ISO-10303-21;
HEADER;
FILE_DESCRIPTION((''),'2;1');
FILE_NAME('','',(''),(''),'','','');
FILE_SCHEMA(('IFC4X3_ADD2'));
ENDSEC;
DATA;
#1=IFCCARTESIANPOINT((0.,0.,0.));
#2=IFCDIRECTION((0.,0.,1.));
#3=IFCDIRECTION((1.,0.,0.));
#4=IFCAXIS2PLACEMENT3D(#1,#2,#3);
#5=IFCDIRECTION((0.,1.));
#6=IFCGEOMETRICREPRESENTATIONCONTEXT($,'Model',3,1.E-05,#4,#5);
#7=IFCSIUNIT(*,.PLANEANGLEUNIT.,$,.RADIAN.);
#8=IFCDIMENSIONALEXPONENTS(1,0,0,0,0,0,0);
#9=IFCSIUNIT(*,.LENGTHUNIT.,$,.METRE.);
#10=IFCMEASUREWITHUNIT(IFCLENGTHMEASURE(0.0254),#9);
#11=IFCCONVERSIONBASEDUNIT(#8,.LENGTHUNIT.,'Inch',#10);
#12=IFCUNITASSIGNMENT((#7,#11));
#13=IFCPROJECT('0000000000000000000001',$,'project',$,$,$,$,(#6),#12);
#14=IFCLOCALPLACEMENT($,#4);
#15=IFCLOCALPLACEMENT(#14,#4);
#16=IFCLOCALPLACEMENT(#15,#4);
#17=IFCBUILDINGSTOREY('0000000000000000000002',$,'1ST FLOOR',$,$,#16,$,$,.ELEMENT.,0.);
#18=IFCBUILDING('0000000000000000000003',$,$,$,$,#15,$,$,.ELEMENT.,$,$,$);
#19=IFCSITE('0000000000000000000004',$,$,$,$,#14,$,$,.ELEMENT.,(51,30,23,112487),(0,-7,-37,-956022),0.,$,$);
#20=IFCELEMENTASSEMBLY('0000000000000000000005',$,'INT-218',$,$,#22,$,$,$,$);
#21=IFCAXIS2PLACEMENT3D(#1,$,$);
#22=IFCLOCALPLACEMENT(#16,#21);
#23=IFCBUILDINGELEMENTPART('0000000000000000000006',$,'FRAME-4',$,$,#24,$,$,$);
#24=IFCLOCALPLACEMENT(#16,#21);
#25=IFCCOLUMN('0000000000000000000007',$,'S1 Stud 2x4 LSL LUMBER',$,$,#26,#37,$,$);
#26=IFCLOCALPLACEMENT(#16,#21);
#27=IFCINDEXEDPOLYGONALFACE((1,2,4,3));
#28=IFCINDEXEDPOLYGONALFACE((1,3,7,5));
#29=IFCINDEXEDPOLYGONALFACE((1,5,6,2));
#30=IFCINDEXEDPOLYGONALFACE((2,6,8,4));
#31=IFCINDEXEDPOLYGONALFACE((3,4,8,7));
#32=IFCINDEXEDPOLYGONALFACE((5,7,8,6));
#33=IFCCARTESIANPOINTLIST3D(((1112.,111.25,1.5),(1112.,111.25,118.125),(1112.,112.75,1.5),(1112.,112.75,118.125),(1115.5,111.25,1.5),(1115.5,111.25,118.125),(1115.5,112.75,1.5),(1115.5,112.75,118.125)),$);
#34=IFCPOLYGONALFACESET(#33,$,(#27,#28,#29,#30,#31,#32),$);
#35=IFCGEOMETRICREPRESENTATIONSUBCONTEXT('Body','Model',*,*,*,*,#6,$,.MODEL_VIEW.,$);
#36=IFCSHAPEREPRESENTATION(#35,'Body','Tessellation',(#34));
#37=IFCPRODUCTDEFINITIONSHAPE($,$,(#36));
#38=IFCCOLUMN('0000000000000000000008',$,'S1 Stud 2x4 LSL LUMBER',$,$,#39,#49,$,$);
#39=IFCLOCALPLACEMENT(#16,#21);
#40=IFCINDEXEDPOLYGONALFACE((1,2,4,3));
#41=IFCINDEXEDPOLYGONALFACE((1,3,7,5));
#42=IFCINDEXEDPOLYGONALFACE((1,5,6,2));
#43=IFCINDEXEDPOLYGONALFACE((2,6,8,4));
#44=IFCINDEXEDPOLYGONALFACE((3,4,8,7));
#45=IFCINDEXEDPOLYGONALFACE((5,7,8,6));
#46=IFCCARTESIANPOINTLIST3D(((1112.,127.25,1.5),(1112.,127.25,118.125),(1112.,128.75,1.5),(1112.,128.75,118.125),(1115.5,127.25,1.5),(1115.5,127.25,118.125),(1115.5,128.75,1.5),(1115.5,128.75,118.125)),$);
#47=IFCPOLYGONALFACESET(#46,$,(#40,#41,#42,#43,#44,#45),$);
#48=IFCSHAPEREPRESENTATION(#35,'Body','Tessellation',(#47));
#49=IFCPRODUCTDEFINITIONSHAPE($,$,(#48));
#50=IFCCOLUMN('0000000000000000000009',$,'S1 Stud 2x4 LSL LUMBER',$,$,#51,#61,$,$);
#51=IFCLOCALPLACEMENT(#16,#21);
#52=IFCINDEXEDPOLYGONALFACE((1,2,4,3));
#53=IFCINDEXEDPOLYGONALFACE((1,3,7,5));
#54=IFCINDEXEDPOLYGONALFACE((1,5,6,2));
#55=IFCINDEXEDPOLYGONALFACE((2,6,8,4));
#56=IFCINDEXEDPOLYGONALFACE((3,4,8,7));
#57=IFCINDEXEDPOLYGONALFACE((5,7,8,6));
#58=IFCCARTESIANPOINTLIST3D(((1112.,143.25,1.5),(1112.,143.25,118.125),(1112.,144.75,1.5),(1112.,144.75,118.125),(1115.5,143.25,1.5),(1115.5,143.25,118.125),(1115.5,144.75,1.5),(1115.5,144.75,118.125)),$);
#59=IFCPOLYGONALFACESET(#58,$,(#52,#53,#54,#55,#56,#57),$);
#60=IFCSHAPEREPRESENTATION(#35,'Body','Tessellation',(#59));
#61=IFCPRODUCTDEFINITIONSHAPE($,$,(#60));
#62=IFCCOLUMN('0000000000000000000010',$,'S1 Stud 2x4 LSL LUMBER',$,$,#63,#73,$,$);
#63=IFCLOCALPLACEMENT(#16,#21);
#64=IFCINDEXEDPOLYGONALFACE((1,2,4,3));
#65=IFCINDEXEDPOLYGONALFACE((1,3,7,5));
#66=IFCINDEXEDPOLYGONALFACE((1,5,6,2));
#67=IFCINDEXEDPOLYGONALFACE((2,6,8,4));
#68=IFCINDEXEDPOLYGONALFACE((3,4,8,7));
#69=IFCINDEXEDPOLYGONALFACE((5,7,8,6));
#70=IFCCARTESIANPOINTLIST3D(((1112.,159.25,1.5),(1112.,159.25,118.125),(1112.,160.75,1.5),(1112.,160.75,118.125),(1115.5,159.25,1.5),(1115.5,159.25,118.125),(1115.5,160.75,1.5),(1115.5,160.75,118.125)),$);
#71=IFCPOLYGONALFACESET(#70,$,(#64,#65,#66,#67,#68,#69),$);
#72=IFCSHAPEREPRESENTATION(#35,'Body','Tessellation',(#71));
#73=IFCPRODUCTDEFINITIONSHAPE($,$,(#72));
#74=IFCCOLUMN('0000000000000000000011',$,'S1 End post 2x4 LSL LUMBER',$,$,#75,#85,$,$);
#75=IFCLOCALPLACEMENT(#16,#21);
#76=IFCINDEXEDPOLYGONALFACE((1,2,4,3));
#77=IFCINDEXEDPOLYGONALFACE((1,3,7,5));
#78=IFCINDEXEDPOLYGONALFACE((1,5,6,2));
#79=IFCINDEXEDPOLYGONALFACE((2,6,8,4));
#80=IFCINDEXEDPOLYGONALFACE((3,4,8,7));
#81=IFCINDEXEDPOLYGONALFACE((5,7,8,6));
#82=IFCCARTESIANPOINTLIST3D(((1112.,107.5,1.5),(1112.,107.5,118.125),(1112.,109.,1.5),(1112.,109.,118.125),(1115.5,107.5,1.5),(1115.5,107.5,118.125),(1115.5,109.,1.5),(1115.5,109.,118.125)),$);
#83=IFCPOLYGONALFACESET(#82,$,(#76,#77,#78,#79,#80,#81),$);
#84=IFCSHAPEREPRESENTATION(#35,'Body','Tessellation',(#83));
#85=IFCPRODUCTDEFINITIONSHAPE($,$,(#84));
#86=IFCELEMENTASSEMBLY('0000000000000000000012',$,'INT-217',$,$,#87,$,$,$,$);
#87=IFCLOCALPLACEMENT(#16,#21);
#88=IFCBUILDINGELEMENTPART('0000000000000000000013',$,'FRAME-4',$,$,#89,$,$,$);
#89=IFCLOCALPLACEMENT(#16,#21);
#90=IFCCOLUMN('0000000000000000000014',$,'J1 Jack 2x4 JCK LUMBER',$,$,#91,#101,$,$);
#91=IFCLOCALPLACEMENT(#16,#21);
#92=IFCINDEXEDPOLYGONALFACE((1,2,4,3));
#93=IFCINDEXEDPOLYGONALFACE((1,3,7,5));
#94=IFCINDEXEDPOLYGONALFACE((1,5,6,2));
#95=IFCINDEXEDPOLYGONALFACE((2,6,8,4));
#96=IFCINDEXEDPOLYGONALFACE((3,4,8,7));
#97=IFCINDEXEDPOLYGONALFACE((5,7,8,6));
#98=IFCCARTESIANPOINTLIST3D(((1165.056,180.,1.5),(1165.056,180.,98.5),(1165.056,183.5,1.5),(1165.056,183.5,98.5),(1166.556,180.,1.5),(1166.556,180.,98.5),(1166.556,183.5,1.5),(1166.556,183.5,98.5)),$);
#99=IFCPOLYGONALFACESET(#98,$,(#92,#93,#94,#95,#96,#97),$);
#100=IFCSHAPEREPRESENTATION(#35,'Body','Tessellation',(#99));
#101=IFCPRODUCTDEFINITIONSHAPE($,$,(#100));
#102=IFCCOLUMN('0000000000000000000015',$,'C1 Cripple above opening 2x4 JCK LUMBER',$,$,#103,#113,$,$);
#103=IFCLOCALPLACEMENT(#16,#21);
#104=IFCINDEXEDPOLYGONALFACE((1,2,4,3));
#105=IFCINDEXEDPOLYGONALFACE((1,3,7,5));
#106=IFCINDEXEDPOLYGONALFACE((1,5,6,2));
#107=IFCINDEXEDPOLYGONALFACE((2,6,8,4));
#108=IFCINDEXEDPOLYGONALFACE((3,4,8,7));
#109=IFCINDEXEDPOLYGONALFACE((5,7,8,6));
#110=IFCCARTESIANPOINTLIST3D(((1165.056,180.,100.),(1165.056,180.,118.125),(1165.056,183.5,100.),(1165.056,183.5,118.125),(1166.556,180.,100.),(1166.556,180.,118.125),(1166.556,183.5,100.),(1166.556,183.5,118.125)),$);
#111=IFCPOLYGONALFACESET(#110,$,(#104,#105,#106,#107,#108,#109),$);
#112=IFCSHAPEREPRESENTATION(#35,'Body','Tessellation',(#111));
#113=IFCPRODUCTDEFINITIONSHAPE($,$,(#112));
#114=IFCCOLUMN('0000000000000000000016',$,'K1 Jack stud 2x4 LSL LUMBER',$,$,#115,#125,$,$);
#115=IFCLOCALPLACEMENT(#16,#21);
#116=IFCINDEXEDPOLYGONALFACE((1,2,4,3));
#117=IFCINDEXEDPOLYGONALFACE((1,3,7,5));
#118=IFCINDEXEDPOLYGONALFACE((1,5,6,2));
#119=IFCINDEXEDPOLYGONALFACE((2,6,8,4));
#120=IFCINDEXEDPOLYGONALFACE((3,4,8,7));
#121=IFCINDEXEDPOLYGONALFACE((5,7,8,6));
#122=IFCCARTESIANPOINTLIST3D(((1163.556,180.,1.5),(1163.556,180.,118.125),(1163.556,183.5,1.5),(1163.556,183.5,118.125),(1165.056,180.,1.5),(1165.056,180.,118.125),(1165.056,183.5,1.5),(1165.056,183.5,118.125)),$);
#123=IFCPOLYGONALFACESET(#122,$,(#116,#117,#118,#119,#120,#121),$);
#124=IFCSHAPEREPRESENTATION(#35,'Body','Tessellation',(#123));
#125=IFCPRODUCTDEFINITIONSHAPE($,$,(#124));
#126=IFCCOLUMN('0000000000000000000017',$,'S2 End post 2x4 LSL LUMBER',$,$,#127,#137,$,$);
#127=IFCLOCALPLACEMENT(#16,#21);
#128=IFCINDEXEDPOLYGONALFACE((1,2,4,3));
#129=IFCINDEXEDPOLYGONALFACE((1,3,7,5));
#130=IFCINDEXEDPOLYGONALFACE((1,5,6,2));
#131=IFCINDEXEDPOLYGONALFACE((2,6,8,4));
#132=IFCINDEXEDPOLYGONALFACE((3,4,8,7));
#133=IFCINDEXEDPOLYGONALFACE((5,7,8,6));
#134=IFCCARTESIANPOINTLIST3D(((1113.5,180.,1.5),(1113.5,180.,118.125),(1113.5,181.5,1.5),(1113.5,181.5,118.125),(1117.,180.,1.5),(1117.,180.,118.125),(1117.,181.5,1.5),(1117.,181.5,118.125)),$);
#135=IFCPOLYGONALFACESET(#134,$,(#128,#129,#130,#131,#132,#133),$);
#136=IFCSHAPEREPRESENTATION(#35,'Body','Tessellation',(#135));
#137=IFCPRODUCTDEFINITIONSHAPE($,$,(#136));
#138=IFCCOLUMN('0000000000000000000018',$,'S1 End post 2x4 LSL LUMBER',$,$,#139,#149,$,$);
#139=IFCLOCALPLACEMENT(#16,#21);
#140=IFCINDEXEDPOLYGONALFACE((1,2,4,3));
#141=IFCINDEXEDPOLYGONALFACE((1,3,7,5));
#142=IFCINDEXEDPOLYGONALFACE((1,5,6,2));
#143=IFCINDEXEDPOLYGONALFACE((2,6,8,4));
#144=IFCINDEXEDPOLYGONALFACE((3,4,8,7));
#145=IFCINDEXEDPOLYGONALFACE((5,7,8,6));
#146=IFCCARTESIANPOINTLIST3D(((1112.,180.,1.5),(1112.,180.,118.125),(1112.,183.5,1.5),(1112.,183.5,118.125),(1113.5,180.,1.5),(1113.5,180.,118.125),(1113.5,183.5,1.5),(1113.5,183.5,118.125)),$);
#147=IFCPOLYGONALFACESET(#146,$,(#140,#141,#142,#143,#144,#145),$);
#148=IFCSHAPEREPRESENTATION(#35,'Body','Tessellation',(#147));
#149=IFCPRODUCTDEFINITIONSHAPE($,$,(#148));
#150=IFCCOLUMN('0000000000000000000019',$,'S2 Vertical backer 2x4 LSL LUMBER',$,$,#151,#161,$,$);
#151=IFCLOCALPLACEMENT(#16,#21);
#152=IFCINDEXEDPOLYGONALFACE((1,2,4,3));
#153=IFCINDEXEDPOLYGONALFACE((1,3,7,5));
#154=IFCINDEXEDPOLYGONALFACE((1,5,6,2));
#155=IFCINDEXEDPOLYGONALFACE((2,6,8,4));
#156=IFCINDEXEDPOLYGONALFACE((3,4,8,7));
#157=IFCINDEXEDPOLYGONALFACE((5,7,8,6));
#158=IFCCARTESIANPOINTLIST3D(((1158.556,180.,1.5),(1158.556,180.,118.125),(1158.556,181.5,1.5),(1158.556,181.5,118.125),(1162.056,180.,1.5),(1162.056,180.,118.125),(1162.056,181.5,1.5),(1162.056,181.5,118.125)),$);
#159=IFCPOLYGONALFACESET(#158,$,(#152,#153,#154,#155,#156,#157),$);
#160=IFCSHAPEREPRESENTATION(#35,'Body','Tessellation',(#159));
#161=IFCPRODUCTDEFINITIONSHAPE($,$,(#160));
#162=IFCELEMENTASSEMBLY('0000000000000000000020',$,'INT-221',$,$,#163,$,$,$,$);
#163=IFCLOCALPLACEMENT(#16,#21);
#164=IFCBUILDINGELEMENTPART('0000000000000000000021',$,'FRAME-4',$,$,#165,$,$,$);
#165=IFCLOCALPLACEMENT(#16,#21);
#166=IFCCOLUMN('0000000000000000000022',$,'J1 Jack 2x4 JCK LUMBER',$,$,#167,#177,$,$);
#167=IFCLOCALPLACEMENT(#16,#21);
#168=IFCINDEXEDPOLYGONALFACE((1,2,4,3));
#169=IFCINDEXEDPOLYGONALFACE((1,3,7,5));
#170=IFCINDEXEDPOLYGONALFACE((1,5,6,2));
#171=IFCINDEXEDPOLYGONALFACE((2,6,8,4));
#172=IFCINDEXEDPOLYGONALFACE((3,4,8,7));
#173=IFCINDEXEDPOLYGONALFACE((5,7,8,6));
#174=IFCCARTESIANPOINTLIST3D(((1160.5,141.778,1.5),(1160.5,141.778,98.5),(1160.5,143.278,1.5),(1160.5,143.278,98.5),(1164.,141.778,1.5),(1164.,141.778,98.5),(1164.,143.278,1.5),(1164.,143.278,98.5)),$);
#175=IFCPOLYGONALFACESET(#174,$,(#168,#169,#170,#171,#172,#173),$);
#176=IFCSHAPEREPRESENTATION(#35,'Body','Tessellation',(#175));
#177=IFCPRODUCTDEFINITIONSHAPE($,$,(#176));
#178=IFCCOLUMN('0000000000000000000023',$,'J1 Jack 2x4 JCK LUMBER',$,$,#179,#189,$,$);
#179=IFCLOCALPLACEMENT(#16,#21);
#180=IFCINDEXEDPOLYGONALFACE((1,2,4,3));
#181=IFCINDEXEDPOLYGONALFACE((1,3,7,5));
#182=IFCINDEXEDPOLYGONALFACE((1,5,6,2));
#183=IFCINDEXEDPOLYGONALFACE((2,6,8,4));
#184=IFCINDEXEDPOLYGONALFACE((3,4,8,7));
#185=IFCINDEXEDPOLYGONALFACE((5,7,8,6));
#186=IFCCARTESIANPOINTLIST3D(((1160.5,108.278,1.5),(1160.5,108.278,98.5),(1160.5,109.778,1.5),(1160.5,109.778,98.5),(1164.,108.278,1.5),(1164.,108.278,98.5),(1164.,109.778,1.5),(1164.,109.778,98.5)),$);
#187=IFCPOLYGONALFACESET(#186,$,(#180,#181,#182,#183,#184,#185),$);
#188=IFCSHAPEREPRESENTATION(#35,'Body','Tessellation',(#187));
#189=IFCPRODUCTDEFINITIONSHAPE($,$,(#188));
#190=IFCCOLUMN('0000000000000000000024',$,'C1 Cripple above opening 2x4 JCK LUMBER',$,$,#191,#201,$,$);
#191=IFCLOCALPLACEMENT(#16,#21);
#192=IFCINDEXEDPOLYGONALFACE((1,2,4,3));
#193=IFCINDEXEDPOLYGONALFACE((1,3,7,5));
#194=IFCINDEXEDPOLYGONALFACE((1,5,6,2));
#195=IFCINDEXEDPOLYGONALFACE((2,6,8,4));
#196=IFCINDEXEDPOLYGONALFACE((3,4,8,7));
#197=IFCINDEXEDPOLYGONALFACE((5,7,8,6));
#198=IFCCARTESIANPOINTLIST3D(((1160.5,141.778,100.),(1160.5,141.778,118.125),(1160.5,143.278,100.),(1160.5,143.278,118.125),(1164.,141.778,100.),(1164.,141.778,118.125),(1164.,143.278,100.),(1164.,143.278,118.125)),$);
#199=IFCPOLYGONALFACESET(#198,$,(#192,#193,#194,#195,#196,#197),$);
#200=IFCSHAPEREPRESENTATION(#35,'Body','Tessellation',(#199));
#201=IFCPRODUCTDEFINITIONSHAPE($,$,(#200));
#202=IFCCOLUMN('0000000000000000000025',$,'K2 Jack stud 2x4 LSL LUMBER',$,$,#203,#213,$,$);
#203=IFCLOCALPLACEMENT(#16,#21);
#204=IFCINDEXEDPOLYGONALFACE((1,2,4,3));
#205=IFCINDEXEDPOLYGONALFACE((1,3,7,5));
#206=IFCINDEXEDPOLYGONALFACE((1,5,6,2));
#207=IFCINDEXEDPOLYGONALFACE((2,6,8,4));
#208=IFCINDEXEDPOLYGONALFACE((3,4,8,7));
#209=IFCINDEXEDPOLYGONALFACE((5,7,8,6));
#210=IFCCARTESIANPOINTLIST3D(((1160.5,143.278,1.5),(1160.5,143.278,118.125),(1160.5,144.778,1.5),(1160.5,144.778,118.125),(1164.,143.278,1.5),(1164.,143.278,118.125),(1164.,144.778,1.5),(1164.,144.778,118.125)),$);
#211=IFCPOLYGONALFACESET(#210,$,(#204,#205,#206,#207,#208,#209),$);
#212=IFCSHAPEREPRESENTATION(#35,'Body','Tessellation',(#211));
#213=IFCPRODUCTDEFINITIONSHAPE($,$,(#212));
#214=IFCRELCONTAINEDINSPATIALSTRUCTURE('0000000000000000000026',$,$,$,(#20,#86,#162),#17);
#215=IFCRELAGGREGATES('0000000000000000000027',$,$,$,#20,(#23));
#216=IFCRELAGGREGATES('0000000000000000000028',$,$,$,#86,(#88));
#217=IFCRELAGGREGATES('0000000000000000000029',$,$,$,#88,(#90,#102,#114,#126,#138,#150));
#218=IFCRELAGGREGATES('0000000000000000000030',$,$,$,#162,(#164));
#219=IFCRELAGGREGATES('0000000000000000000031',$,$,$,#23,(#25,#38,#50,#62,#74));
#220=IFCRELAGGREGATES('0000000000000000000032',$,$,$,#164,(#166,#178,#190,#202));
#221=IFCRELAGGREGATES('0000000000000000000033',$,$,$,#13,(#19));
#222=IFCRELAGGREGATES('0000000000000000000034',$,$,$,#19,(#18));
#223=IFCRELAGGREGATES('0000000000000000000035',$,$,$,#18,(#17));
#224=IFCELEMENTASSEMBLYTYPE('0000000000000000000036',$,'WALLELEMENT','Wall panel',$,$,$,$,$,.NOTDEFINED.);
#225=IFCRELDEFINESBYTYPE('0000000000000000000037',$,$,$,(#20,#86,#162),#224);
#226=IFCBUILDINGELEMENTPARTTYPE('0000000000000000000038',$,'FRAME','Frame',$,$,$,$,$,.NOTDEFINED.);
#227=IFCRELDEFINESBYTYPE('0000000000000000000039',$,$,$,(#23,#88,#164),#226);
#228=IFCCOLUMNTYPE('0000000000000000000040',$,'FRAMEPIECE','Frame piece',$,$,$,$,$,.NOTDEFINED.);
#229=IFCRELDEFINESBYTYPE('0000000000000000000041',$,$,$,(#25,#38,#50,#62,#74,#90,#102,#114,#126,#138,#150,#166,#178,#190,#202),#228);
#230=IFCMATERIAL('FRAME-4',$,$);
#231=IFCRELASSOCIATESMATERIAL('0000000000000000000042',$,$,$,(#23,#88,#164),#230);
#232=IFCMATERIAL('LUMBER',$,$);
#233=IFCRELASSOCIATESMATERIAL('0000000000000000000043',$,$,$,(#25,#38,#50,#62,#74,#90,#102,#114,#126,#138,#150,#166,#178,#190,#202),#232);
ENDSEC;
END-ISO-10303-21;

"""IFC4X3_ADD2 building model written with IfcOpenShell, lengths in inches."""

from ifc_helpers import new_model, entity, si_unit, converted_unit, direction, frame, origin_with_axes, origin_2d_with_axis, place, context, subcontext, project, spatial, rectangle, extrude, material, type_object, element, aggregate, save


model = new_model("IFC4X3_ADD2")

# Units and contexts
model_context = context("Model", 3, precision=1e-05, world=origin_with_axes(), true_north=direction((0.0, 1.0)))
body_context = subcontext(model_context, "Body", "Model", "MODEL_VIEW")
ifc_project = project(units=[si_unit("PLANEANGLEUNIT", "RADIAN"), converted_unit("LENGTHUNIT", "Inch", entity("IfcLengthMeasure", 0.0254), si_unit("LENGTHUNIT", "METRE"), dimensions=[1, 0, 0, 0, 0, 0, 0])], contexts=[model_context])

# Site, building, storey
site_placement = place(None, origin_with_axes())
site = spatial("IfcSite", under=ifc_project, at=site_placement, CompositionType="ELEMENT", RefLatitude=(51, 30, 23, 112487), RefLongitude=(0, -7, -37, -956022), RefElevation=0.0)
building_placement = place(site_placement, origin_with_axes())
building = spatial("IfcBuilding", under=site, at=building_placement, CompositionType="ELEMENT")
storey_placement = place(building_placement, origin_with_axes())
storey = spatial("IfcBuildingStorey", under=building, at=storey_placement, Name="1ST FLOOR", CompositionType="ELEMENT", Elevation=0.0)

# Element assemblies, building element parts, columns
element_assembly_type = type_object("IfcElementAssemblyType", Name="WALLELEMENT", Description="Wall panel", PredefinedType="NOTDEFINED")
assembly_1_placement = place(storey_placement, origin_with_axes())
assembly_1 = element("IfcElementAssembly", 1, at=assembly_1_placement, inside=storey, type_object=element_assembly_type, Name="INT-218")
ifc_material_1 = material(Name="FRAME-4")
building_element_part_type = type_object("IfcBuildingElementPartType", Name="FRAME", Description="Frame", PredefinedType="NOTDEFINED")
building_element_part_1_placement = place(storey_placement, origin_with_axes())
building_element_part_1 = element("IfcBuildingElementPart", 2, at=building_element_part_1_placement, type_object=building_element_part_type, material=ifc_material_1, Name="FRAME-4")
aggregate(assembly_1, [building_element_part_1])
ifc_material_2 = material(Name="LUMBER")
column_type = type_object("IfcColumnType", Name="FRAMEPIECE", Description="Frame piece", PredefinedType="NOTDEFINED")
column_1_placement = place(storey_placement, frame((1113.75, 112.0, 118.125), z_axis=(0.0, 0.0, -1.0), x_axis=(0.0, -1.0, 0.0)))
column_1 = element("IfcColumn", 3, at=column_1_placement, type_object=column_type, material=ifc_material_2, Name="S1 Stud 2x4 LSL LUMBER", context=body_context, shape_type="SweptSolid", body=[
    extrude(rectangle(XDim=1.5, YDim=3.5, at=origin_2d_with_axis()), origin_with_axes(), (0.0, 0.0, 1.0), 116.625),
])
column_2_placement = place(storey_placement, frame((1113.75, 128.0, 118.125), z_axis=(0.0, 0.0, -1.0), x_axis=(0.0, -1.0, 0.0)))
column_2 = element("IfcColumn", 4, at=column_2_placement, type_object=column_type, material=ifc_material_2, Name="S1 Stud 2x4 LSL LUMBER", context=body_context, shape_type="SweptSolid", body=[
    extrude(rectangle(XDim=1.5, YDim=3.5, at=origin_2d_with_axis()), origin_with_axes(), (0.0, 0.0, 1.0), 116.625),
])
column_3_placement = place(storey_placement, frame((1113.75, 144.0, 118.125), z_axis=(0.0, 0.0, -1.0), x_axis=(0.0, -1.0, 0.0)))
column_3 = element("IfcColumn", 5, at=column_3_placement, type_object=column_type, material=ifc_material_2, Name="S1 Stud 2x4 LSL LUMBER", context=body_context, shape_type="SweptSolid", body=[
    extrude(rectangle(XDim=1.5, YDim=3.5, at=origin_2d_with_axis()), origin_with_axes(), (0.0, 0.0, 1.0), 116.625),
])
column_4_placement = place(storey_placement, frame((1113.75, 160.0, 118.125), z_axis=(0.0, 0.0, -1.0), x_axis=(0.0, -1.0, 0.0)))
column_4 = element("IfcColumn", 6, at=column_4_placement, type_object=column_type, material=ifc_material_2, Name="S1 Stud 2x4 LSL LUMBER", context=body_context, shape_type="SweptSolid", body=[
    extrude(rectangle(XDim=1.5, YDim=3.5, at=origin_2d_with_axis()), origin_with_axes(), (0.0, 0.0, 1.0), 116.625),
])
column_5_placement = place(storey_placement, frame((1113.75, 108.25, 1.5), z_axis=(0.0, 0.0, 1.0), x_axis=(0.0, 1.0, 0.0)))
column_5 = element("IfcColumn", 7, at=column_5_placement, type_object=column_type, material=ifc_material_2, Name="S1 End post 2x4 LSL LUMBER", context=body_context, shape_type="SweptSolid", body=[
    extrude(rectangle(XDim=1.5, YDim=3.5, at=origin_2d_with_axis()), origin_with_axes(), (0.0, 0.0, 1.0), 116.625),
])
assembly_2_placement = place(storey_placement, origin_with_axes())
assembly_2 = element("IfcElementAssembly", 8, at=assembly_2_placement, inside=storey, type_object=element_assembly_type, Name="INT-217")
building_element_part_2_placement = place(storey_placement, origin_with_axes())
building_element_part_2 = element("IfcBuildingElementPart", 9, at=building_element_part_2_placement, type_object=building_element_part_type, material=ifc_material_1, Name="FRAME-4")
aggregate(assembly_2, [building_element_part_2])
column_6_placement = place(storey_placement, frame((1165.806, 181.75, 1.5), z_axis=(0.0, 0.0, 1.0), x_axis=(1.0, 0.0, 0.0)))
column_6 = element("IfcColumn", 10, at=column_6_placement, type_object=column_type, material=ifc_material_2, Name="J1 Jack 2x4 JCK LUMBER", context=body_context, shape_type="SweptSolid", body=[
    extrude(rectangle(XDim=1.5, YDim=3.5, at=origin_2d_with_axis()), origin_with_axes(), (0.0, 0.0, 1.0), 97.0),
])
column_7_placement = place(storey_placement, frame((1165.806, 181.75, 100.0), z_axis=(0.0, 0.0, 1.0), x_axis=(1.0, 0.0, 0.0)))
column_7 = element("IfcColumn", 11, at=column_7_placement, type_object=column_type, material=ifc_material_2, Name="C1 Cripple above opening 2x4 JCK LUMBER", context=body_context, shape_type="SweptSolid", body=[
    extrude(rectangle(XDim=1.5, YDim=3.5, at=origin_2d_with_axis()), origin_with_axes(), (0.0, 0.0, 1.0), 18.125),
])
column_8_placement = place(storey_placement, frame((1164.306, 181.75, 1.5), z_axis=(0.0, 0.0, 1.0), x_axis=(1.0, 0.0, 0.0)))
column_8 = element("IfcColumn", 12, at=column_8_placement, type_object=column_type, material=ifc_material_2, Name="K1 Jack stud 2x4 LSL LUMBER", context=body_context, shape_type="SweptSolid", body=[
    extrude(rectangle(XDim=1.5, YDim=3.5, at=origin_2d_with_axis()), origin_with_axes(), (0.0, 0.0, 1.0), 116.625),
])
column_9_placement = place(storey_placement, frame((1115.25, 180.75, 1.5), z_axis=(0.0, 0.0, 1.0), x_axis=(0.0, -1.0, 0.0)))
column_9 = element("IfcColumn", 13, at=column_9_placement, type_object=column_type, material=ifc_material_2, Name="S2 End post 2x4 LSL LUMBER", context=body_context, shape_type="SweptSolid", body=[
    extrude(rectangle(XDim=1.5, YDim=3.5, at=origin_2d_with_axis()), origin_with_axes(), (0.0, 0.0, 1.0), 116.625),
])
column_10_placement = place(storey_placement, frame((1112.75, 181.75, 1.5), z_axis=(0.0, 0.0, 1.0), x_axis=(1.0, 0.0, 0.0)))
column_10 = element("IfcColumn", 14, at=column_10_placement, type_object=column_type, material=ifc_material_2, Name="S1 End post 2x4 LSL LUMBER", context=body_context, shape_type="SweptSolid", body=[
    extrude(rectangle(XDim=1.5, YDim=3.5, at=origin_2d_with_axis()), origin_with_axes(), (0.0, 0.0, 1.0), 116.625),
])
column_11_placement = place(storey_placement, frame((1160.306, 180.75, 1.5), z_axis=(0.0, 0.0, 1.0), x_axis=(0.0, -1.0, 0.0)))
column_11 = element("IfcColumn", 15, at=column_11_placement, type_object=column_type, material=ifc_material_2, Name="S2 Vertical backer 2x4 LSL LUMBER", context=body_context, shape_type="SweptSolid", body=[
    extrude(rectangle(XDim=1.5, YDim=3.5, at=origin_2d_with_axis()), origin_with_axes(), (0.0, 0.0, 1.0), 116.625),
])
aggregate(building_element_part_2, [column_6, column_7, column_8, column_9, column_10, column_11])
assembly_3_placement = place(storey_placement, origin_with_axes())
assembly_3 = element("IfcElementAssembly", 16, at=assembly_3_placement, inside=storey, type_object=element_assembly_type, Name="INT-221")
building_element_part_3_placement = place(storey_placement, origin_with_axes())
building_element_part_3 = element("IfcBuildingElementPart", 17, at=building_element_part_3_placement, type_object=building_element_part_type, material=ifc_material_1, Name="FRAME-4")
aggregate(assembly_3, [building_element_part_3])
column_12_placement = place(storey_placement, frame((1162.25, 142.528, 1.5), z_axis=(0.0, 0.0, 1.0), x_axis=(0.0, -1.0, 0.0)))
column_12 = element("IfcColumn", 18, at=column_12_placement, type_object=column_type, material=ifc_material_2, Name="J1 Jack 2x4 JCK LUMBER", context=body_context, shape_type="SweptSolid", body=[
    extrude(rectangle(XDim=1.5, YDim=3.5, at=origin_2d_with_axis()), origin_with_axes(), (0.0, 0.0, 1.0), 97.0),
])
column_13_placement = place(storey_placement, frame((1162.25, 109.028, 98.5), z_axis=(0.0, 0.0, -1.0), x_axis=(0.0, 1.0, 0.0)))
column_13 = element("IfcColumn", 19, at=column_13_placement, type_object=column_type, material=ifc_material_2, Name="J1 Jack 2x4 JCK LUMBER", context=body_context, shape_type="SweptSolid", body=[
    extrude(rectangle(XDim=1.5, YDim=3.5, at=origin_2d_with_axis()), origin_with_axes(), (0.0, 0.0, 1.0), 97.0),
])
column_14_placement = place(storey_placement, frame((1162.25, 142.528, 100.0), z_axis=(0.0, 0.0, 1.0), x_axis=(0.0, -1.0, 0.0)))
column_14 = element("IfcColumn", 20, at=column_14_placement, type_object=column_type, material=ifc_material_2, Name="C1 Cripple above opening 2x4 JCK LUMBER", context=body_context, shape_type="SweptSolid", body=[
    extrude(rectangle(XDim=1.5, YDim=3.5, at=origin_2d_with_axis()), origin_with_axes(), (0.0, 0.0, 1.0), 18.125),
])
column_15_placement = place(storey_placement, frame((1162.25, 144.028, 1.5), z_axis=(0.0, 0.0, 1.0), x_axis=(0.0, -1.0, 0.0)))
column_15 = element("IfcColumn", 21, at=column_15_placement, type_object=column_type, material=ifc_material_2, Name="K2 Jack stud 2x4 LSL LUMBER", context=body_context, shape_type="SweptSolid", body=[
    extrude(rectangle(XDim=1.5, YDim=3.5, at=origin_2d_with_axis()), origin_with_axes(), (0.0, 0.0, 1.0), 116.625),
])

aggregate(building_element_part_1, [column_1, column_2, column_3, column_4, column_5])
aggregate(building_element_part_3, [column_12, column_13, column_14, column_15])

save(model, "model.ifc")
